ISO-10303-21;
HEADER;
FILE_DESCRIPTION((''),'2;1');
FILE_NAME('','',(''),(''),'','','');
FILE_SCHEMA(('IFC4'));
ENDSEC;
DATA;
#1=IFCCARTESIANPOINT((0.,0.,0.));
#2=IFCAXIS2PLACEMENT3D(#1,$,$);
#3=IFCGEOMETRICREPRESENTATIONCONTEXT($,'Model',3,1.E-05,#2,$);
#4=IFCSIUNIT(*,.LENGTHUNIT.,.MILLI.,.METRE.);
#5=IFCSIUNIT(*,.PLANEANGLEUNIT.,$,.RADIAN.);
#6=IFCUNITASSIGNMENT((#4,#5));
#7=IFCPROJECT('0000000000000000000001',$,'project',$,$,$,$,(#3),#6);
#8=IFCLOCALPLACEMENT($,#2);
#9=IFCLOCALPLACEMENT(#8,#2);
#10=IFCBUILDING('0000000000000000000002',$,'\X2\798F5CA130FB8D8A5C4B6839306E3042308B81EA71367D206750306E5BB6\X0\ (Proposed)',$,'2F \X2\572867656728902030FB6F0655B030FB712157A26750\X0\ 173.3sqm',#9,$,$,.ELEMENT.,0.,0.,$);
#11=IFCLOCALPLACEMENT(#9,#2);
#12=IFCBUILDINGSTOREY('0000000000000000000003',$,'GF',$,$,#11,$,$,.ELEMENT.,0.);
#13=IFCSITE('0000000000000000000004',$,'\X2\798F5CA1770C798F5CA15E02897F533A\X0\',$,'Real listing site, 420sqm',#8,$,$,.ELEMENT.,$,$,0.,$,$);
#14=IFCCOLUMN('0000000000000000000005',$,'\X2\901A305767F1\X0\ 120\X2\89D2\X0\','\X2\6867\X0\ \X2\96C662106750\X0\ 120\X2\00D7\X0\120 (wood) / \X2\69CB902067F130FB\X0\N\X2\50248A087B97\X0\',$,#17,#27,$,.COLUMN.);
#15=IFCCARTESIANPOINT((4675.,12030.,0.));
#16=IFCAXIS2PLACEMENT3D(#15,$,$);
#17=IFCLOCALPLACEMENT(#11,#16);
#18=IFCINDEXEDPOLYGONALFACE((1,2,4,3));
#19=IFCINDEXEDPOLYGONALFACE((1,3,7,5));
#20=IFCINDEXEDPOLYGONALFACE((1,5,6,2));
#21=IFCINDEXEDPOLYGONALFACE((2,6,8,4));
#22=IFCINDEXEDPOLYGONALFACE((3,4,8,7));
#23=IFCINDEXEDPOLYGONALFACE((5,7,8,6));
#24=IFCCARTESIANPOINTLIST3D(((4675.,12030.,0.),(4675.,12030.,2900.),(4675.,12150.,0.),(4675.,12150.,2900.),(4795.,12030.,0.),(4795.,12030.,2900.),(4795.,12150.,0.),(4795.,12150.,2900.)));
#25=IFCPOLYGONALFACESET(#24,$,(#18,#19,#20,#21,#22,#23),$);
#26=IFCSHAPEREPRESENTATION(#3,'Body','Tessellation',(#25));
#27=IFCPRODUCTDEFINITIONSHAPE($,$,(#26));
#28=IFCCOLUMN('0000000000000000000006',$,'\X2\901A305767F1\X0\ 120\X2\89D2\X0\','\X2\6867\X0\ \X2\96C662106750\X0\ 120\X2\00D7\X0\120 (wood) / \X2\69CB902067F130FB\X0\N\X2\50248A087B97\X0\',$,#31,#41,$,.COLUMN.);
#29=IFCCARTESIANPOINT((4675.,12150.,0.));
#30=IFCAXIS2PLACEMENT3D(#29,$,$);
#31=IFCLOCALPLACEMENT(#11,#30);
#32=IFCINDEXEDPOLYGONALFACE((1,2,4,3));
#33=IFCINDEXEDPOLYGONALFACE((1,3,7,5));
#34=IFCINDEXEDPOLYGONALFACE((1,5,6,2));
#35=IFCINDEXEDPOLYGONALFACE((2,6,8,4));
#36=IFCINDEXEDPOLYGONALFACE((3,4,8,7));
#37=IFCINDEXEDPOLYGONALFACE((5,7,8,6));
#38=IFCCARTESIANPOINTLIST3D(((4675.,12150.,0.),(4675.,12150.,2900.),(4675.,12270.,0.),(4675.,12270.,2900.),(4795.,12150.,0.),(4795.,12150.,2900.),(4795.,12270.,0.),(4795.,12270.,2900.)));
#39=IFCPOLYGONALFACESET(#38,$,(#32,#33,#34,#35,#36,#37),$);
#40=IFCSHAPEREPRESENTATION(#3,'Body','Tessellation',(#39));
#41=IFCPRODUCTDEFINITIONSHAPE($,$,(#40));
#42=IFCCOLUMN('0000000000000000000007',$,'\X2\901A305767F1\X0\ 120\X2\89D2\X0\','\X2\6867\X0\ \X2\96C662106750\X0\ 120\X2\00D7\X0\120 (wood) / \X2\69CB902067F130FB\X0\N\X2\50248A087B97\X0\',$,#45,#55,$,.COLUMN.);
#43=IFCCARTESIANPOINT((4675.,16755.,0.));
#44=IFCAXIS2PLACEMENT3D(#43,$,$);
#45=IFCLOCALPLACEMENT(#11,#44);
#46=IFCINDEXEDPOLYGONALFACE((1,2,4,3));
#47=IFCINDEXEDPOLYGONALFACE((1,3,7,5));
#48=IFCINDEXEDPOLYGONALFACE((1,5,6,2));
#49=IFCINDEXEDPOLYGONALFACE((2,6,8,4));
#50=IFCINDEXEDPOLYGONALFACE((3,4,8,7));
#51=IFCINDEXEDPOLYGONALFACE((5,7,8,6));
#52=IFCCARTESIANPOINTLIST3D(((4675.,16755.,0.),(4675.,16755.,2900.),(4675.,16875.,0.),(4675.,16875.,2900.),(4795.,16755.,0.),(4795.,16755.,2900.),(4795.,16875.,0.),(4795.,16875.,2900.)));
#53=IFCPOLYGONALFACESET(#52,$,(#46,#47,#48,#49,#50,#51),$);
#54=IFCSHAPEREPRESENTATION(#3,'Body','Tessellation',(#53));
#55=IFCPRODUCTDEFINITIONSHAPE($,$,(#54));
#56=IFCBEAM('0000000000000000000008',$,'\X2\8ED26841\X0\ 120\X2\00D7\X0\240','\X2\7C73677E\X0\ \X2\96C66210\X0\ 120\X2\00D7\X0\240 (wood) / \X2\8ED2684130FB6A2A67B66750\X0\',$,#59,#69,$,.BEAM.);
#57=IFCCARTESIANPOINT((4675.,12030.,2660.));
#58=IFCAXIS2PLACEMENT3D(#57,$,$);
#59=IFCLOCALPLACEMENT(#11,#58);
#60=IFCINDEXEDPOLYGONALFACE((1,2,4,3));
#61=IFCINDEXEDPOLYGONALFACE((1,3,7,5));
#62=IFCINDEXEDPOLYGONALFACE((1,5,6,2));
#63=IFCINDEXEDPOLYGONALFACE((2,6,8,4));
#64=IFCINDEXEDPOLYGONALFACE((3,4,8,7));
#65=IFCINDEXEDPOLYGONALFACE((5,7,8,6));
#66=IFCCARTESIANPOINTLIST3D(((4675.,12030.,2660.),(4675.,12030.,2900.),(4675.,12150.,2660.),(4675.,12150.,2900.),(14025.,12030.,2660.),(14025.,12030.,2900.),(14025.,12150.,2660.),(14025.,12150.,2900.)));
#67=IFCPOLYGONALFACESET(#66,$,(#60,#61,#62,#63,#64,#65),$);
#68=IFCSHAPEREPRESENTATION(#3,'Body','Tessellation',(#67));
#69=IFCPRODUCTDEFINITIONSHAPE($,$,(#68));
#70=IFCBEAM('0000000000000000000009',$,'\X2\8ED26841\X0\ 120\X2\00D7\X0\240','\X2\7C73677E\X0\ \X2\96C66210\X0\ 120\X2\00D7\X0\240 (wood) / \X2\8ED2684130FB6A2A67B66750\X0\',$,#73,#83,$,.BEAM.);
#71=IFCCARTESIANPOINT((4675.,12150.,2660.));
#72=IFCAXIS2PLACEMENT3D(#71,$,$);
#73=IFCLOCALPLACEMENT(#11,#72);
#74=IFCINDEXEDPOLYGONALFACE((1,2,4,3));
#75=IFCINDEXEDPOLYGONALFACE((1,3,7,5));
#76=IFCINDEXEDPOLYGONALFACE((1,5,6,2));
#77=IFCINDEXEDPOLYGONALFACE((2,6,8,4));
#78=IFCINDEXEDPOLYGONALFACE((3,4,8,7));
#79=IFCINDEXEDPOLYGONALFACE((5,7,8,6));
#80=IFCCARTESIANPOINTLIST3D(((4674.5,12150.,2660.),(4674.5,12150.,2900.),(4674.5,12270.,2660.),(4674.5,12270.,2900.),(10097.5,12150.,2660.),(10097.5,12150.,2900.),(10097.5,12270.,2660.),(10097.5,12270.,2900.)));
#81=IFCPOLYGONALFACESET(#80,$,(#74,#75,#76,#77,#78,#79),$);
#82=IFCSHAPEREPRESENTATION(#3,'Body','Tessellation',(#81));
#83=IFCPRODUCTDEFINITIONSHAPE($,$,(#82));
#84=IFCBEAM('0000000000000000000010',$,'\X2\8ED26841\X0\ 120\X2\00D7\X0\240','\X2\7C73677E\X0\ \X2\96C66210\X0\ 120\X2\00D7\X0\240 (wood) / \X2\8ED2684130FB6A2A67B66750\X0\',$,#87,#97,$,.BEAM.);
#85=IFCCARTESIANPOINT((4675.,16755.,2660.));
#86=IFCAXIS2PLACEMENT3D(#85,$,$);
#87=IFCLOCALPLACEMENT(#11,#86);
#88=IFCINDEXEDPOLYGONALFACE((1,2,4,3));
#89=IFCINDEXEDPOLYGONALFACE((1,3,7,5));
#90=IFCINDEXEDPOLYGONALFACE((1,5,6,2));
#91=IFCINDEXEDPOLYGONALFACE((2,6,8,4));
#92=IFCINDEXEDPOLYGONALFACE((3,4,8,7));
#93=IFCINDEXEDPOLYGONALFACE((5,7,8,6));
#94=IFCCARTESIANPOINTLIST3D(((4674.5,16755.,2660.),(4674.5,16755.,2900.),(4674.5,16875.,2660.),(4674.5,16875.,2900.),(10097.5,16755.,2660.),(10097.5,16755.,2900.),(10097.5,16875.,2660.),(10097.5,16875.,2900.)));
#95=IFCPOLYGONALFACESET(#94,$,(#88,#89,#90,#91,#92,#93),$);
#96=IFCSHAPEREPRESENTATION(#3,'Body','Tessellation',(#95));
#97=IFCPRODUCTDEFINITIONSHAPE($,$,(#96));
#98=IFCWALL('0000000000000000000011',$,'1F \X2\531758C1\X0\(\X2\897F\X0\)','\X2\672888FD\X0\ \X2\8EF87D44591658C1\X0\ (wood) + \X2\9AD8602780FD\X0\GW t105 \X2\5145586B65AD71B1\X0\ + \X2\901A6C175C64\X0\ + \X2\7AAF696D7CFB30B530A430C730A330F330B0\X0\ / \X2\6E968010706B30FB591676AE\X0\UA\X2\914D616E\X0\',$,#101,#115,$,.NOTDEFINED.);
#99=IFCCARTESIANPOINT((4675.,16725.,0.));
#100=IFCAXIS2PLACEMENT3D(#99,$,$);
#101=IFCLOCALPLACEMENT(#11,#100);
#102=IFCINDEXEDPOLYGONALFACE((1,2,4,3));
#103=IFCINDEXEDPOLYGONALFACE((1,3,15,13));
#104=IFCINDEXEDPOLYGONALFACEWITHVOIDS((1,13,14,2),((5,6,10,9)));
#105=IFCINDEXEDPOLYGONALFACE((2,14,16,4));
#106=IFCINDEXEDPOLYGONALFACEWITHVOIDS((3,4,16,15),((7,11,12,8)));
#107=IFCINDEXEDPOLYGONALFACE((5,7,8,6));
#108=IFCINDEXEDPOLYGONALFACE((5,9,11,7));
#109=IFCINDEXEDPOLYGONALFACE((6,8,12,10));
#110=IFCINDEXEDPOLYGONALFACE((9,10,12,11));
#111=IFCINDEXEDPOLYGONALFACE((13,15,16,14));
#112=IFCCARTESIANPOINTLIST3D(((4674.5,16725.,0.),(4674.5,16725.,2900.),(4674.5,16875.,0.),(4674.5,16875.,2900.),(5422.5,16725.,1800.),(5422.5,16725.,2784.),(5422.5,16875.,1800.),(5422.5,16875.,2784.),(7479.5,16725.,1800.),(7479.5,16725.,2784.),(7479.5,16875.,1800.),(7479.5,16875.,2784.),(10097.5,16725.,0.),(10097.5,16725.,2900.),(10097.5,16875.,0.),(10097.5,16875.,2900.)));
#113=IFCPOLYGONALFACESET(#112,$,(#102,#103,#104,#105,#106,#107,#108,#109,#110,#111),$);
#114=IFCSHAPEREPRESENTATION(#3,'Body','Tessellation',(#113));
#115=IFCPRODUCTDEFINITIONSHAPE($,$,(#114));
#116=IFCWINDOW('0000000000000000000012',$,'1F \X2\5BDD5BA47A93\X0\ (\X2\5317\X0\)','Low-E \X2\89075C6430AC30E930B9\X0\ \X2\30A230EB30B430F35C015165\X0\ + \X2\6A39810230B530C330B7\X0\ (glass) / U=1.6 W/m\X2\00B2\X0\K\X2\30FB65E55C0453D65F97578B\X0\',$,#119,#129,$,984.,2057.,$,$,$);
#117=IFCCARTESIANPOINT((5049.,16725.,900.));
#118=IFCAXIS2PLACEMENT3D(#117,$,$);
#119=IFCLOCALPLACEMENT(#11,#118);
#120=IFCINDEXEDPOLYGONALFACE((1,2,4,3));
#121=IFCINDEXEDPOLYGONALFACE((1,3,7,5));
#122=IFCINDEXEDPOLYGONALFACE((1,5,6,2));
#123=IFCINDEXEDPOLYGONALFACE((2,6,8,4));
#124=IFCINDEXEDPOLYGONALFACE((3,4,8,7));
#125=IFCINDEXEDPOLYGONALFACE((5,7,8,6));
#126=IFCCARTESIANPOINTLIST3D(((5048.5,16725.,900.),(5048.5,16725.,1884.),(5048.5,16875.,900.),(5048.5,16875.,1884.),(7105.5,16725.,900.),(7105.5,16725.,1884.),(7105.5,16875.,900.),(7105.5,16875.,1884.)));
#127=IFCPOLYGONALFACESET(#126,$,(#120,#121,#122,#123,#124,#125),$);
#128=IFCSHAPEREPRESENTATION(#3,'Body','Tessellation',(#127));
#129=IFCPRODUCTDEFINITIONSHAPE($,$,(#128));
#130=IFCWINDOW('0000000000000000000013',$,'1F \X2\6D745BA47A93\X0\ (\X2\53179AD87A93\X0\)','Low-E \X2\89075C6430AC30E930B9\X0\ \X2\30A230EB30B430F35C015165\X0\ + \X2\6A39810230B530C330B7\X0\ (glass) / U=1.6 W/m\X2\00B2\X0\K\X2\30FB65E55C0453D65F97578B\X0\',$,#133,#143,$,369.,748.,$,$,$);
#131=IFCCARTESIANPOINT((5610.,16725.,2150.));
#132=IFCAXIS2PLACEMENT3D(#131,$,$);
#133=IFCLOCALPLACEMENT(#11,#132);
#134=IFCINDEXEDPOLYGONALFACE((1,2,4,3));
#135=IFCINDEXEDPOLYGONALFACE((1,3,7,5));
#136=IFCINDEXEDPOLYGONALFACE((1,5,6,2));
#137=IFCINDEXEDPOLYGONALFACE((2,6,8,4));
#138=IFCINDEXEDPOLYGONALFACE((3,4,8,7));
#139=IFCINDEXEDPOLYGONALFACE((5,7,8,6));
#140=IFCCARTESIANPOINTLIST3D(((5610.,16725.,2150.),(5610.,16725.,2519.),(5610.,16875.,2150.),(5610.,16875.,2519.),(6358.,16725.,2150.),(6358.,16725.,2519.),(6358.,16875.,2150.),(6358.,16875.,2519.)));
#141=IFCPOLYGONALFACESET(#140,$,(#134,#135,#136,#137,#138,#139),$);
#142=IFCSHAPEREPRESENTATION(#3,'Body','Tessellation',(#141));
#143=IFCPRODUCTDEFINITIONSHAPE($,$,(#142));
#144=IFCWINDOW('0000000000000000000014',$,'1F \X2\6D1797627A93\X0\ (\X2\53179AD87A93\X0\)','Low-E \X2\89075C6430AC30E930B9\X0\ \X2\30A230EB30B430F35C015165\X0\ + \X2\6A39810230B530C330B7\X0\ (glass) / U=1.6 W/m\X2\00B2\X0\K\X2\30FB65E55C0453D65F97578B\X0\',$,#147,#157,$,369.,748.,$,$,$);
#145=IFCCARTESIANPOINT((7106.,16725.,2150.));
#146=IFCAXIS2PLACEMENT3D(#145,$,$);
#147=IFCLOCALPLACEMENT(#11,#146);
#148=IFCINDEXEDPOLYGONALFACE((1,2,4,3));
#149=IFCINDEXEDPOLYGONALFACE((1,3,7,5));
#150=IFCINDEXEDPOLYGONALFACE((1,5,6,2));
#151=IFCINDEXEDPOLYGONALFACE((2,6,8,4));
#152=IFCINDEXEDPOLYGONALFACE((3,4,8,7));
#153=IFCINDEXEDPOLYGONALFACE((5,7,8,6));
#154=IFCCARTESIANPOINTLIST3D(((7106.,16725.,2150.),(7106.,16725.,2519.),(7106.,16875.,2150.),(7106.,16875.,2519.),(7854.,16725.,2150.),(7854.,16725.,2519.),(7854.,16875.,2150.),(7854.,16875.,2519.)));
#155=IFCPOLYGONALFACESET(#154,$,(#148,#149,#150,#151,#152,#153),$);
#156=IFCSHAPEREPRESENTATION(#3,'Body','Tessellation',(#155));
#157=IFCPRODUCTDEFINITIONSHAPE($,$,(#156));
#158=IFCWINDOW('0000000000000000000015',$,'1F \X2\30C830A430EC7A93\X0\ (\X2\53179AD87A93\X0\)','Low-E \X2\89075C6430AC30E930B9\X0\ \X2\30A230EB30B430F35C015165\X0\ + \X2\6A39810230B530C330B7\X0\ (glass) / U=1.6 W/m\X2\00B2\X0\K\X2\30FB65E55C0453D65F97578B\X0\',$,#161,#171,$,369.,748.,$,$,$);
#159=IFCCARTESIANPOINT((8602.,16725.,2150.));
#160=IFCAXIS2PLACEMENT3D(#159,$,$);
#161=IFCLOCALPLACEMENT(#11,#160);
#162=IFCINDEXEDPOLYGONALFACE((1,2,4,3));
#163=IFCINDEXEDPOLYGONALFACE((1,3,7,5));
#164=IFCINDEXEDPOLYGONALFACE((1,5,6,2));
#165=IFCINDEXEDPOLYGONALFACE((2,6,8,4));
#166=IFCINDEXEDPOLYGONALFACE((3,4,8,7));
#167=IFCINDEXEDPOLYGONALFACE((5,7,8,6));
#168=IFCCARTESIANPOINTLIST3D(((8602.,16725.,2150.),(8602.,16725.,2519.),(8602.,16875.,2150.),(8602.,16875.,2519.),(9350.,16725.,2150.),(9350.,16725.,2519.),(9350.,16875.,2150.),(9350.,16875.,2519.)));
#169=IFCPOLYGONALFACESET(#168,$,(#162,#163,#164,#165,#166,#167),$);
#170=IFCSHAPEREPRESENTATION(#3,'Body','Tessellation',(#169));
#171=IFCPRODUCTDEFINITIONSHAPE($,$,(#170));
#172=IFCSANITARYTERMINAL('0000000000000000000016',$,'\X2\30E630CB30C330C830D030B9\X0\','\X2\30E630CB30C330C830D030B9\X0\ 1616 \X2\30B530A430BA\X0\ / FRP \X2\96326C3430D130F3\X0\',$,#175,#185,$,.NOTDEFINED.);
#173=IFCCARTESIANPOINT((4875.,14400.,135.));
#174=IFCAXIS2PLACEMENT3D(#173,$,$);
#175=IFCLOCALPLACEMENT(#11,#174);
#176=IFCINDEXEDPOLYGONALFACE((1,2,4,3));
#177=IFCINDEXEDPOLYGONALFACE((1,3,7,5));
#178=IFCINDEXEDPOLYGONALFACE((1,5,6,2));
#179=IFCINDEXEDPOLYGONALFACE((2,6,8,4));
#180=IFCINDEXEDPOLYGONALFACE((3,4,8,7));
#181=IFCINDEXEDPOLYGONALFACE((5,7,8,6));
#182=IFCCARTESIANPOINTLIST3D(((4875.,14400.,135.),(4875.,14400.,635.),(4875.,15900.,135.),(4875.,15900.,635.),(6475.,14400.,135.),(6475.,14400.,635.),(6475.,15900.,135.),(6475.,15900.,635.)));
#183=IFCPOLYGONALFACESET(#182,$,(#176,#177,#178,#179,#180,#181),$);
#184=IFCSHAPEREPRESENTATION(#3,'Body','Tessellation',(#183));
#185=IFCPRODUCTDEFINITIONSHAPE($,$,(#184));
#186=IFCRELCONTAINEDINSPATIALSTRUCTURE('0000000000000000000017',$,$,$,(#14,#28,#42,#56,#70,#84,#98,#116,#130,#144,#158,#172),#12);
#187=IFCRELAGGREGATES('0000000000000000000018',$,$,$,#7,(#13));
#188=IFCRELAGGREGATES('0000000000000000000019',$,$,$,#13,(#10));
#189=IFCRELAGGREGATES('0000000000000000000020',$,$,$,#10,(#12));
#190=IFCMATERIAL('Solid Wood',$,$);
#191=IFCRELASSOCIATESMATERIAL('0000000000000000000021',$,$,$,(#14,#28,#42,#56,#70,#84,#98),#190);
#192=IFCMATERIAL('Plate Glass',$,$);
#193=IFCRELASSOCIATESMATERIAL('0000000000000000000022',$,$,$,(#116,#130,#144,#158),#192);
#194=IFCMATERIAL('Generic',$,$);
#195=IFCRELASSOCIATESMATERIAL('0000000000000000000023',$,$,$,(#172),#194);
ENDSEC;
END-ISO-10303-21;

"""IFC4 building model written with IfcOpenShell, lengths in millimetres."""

from ifc_helpers import new_model, si_unit, frame, frame_2d, origin, place, context, project, spatial, rectangle, extrude, material, element, fill, save


model = new_model("IFC4")

# Units and contexts
model_context = context("Model", 3, precision=1e-05, world=origin())
ifc_project = project(units=[si_unit("LENGTHUNIT", "METRE", prefix="MILLI"), si_unit("PLANEANGLEUNIT", "RADIAN")], contexts=[model_context])

# Site, building, storey
site_placement = place(None, origin())
site = spatial("IfcSite", under=ifc_project, at=site_placement, Name="福岡県福岡市西区", ObjectType="Real listing site, 420sqm", CompositionType="ELEMENT", RefElevation=0.0)
building_placement = place(site_placement, origin())
building = spatial("IfcBuilding", under=site, at=building_placement, Name="福岡・越屋根のある自然素材の家 (Proposed)", ObjectType="2F 在来木造・漆喰・無垢材 173.3sqm", CompositionType="ELEMENT", ElevationOfRefHeight=0.0, ElevationOfTerrain=0.0)
storey_placement = place(building_placement, origin())
storey = spatial("IfcBuildingStorey", under=building, at=storey_placement, Name="GF", CompositionType="ELEMENT", Elevation=0.0)

# Columns
ifc_material_1 = material(Name="Solid Wood")
column_1_placement = place(storey_placement, frame((4675.0, 12030.0, 0.0)))
element("IfcColumn", 1, at=column_1_placement, inside=storey, material=ifc_material_1, Name="通し柱 120角", Description="桧 集成材 120×120 (wood) / 構造柱・N値計算", PredefinedType="COLUMN", context=model_context, shape_type="SweptSolid", body=[
    extrude(rectangle(XDim=120.0, YDim=120.0, at=frame_2d((60.0, 60.0))), frame((4675.0, 12030.0, 0.0)), (0.0, 0.0, 1.0), 2900.0),
])
column_2_placement = place(storey_placement, frame((4675.0, 12150.0, 0.0)))
element("IfcColumn", 2, at=column_2_placement, inside=storey, material=ifc_material_1, Name="通し柱 120角", Description="桧 集成材 120×120 (wood) / 構造柱・N値計算", PredefinedType="COLUMN", context=model_context, shape_type="SweptSolid", body=[
    extrude(rectangle(XDim=120.0, YDim=120.0, at=frame_2d((60.0, 60.0))), frame((4675.0, 12150.0, 0.0)), (0.0, 0.0, 1.0), 2900.0),
])
column_3_placement = place(storey_placement, frame((4675.0, 16755.0, 0.0)))
element("IfcColumn", 3, at=column_3_placement, inside=storey, material=ifc_material_1, Name="通し柱 120角", Description="桧 集成材 120×120 (wood) / 構造柱・N値計算", PredefinedType="COLUMN", context=model_context, shape_type="SweptSolid", body=[
    extrude(rectangle(XDim=120.0, YDim=120.0, at=frame_2d((60.0, 60.0))), frame((4675.0, 16755.0, 0.0)), (0.0, 0.0, 1.0), 2900.0),
])

# Beams
beam_1_placement = place(storey_placement, frame((4675.0, 12030.0, 2660.0)))
element("IfcBeam", 4, at=beam_1_placement, inside=storey, material=ifc_material_1, Name="軒桁 120×240", Description="米松 集成 120×240 (wood) / 軒桁・横架材", PredefinedType="BEAM", context=model_context, shape_type="SweptSolid", body=[
    extrude(rectangle(XDim=9350.0, YDim=120.0, at=frame_2d((4675.0, 60.0))), frame((4675.0, 12030.0, 2660.0)), (0.0, 0.0, 1.0), 240.0),
])
beam_2_placement = place(storey_placement, frame((4675.0, 12150.0, 2660.0)))
element("IfcBeam", 5, at=beam_2_placement, inside=storey, material=ifc_material_1, Name="軒桁 120×240", Description="米松 集成 120×240 (wood) / 軒桁・横架材", PredefinedType="BEAM", context=model_context, shape_type="SweptSolid", body=[
    extrude(rectangle(XDim=5423.0, YDim=120.0, at=frame_2d((2711.0, 60.0))), frame((4675.0, 12150.0, 2660.0)), (0.0, 0.0, 1.0), 240.0),
])
beam_3_placement = place(storey_placement, frame((4675.0, 16755.0, 2660.0)))
element("IfcBeam", 6, at=beam_3_placement, inside=storey, material=ifc_material_1, Name="軒桁 120×240", Description="米松 集成 120×240 (wood) / 軒桁・横架材", PredefinedType="BEAM", context=model_context, shape_type="SweptSolid", body=[
    extrude(rectangle(XDim=5423.0, YDim=120.0, at=frame_2d((2711.0, 60.0))), frame((4675.0, 16755.0, 2660.0)), (0.0, 0.0, 1.0), 240.0),
])

# Wall, openings, windows
wall_1_placement = place(storey_placement, frame((4675.0, 16725.0, 0.0)))
wall_1 = element("IfcWall", 7, at=wall_1_placement, inside=storey, material=ifc_material_1, Name="1F 北壁(西)", Description="木製 軸組外壁 (wood) + 高性能GW t105 充填断熱 + 通気層 + 窯業系サイディング / 準耐火・外皮UA配慮", PredefinedType="NOTDEFINED", context=model_context, shape_type="SweptSolid", body=[
    extrude(rectangle(XDim=5423.0, YDim=150.0, at=frame_2d((2711.0, 75.0))), frame((4675.0, 16725.0, 0.0)), (0.0, 0.0, 1.0), 2900.0),
])
opening_1_placement = place(storey_placement, frame((5049.0, 16725.0, 900.0)))
opening_1 = element("IfcOpeningElement", 8, at=opening_1_placement, cuts=wall_1, PredefinedType="NOTDEFINED", context=model_context, shape_type="SweptSolid", body=[
    extrude(rectangle(XDim=2057.0, YDim=150.0, at=frame_2d((1028.0, 75.0))), frame((5049.0, 16725.0, 900.0)), (0.0, 0.0, 1.0), 984.0),
])
opening_2_placement = place(storey_placement, frame((5610.0, 16725.0, 2150.0)))
opening_2 = element("IfcOpeningElement", 9, at=opening_2_placement, cuts=wall_1, PredefinedType="NOTDEFINED", context=model_context, shape_type="SweptSolid", body=[
    extrude(rectangle(XDim=748.0, YDim=150.0, at=frame_2d((374.0, 75.0))), frame((5610.0, 16725.0, 2150.0)), (0.0, 0.0, 1.0), 369.0),
])
opening_3_placement = place(storey_placement, frame((7106.0, 16725.0, 2150.0)))
opening_3 = element("IfcOpeningElement", 10, at=opening_3_placement, cuts=wall_1, PredefinedType="NOTDEFINED", context=model_context, shape_type="SweptSolid", body=[
    extrude(rectangle(XDim=748.0, YDim=150.0, at=frame_2d((374.0, 75.0))), frame((7106.0, 16725.0, 2150.0)), (0.0, 0.0, 1.0), 369.0),
])
opening_4_placement = place(storey_placement, frame((8602.0, 16725.0, 2150.0)))
opening_4 = element("IfcOpeningElement", 11, at=opening_4_placement, cuts=wall_1, PredefinedType="NOTDEFINED", context=model_context, shape_type="SweptSolid", body=[
    extrude(rectangle(XDim=748.0, YDim=150.0, at=frame_2d((374.0, 75.0))), frame((8602.0, 16725.0, 2150.0)), (0.0, 0.0, 1.0), 369.0),
])
ifc_material_2 = material(Name="Plate Glass")
window_1_placement = place(storey_placement, frame((5049.0, 16725.0, 900.0)))
window_1 = element("IfcWindow", 12, at=window_1_placement, inside=storey, material=ifc_material_2, Name="1F 寝室窓 (北)", Description="Low-E 複層ガラス アルゴン封入 + 樹脂サッシ (glass) / U=1.6 W/m²K・日射取得型", OverallHeight=984.0, OverallWidth=2057.0, context=model_context, shape_type="SweptSolid", body=[
    extrude(rectangle(XDim=2057.0, YDim=150.0, at=frame_2d((1028.0, 75.0))), frame((5049.0, 16725.0, 900.0)), (0.0, 0.0, 1.0), 984.0),
])
fill(opening_1, window_1)
window_2_placement = place(storey_placement, frame((5610.0, 16725.0, 2150.0)))
window_2 = element("IfcWindow", 13, at=window_2_placement, inside=storey, material=ifc_material_2, Name="1F 浴室窓 (北高窓)", Description="Low-E 複層ガラス アルゴン封入 + 樹脂サッシ (glass) / U=1.6 W/m²K・日射取得型", OverallHeight=369.0, OverallWidth=748.0, context=model_context, shape_type="SweptSolid", body=[
    extrude(rectangle(XDim=748.0, YDim=150.0, at=frame_2d((374.0, 75.0))), frame((5610.0, 16725.0, 2150.0)), (0.0, 0.0, 1.0), 369.0),
])
fill(opening_2, window_2)
window_3_placement = place(storey_placement, frame((7106.0, 16725.0, 2150.0)))
window_3 = element("IfcWindow", 14, at=window_3_placement, inside=storey, material=ifc_material_2, Name="1F 洗面窓 (北高窓)", Description="Low-E 複層ガラス アルゴン封入 + 樹脂サッシ (glass) / U=1.6 W/m²K・日射取得型", OverallHeight=369.0, OverallWidth=748.0, context=model_context, shape_type="SweptSolid", body=[
    extrude(rectangle(XDim=748.0, YDim=150.0, at=frame_2d((374.0, 75.0))), frame((7106.0, 16725.0, 2150.0)), (0.0, 0.0, 1.0), 369.0),
])
fill(opening_3, window_3)
window_4_placement = place(storey_placement, frame((8602.0, 16725.0, 2150.0)))
window_4 = element("IfcWindow", 15, at=window_4_placement, inside=storey, material=ifc_material_2, Name="1F トイレ窓 (北高窓)", Description="Low-E 複層ガラス アルゴン封入 + 樹脂サッシ (glass) / U=1.6 W/m²K・日射取得型", OverallHeight=369.0, OverallWidth=748.0, context=model_context, shape_type="SweptSolid", body=[
    extrude(rectangle(XDim=748.0, YDim=150.0, at=frame_2d((374.0, 75.0))), frame((8602.0, 16725.0, 2150.0)), (0.0, 0.0, 1.0), 369.0),
])
fill(opening_4, window_4)

# Shared definitions
ifc_material_3 = material(Name="Generic")

# Sanitary terminal
sanitary_terminal_placement = place(storey_placement, frame((4875.0, 14400.0, 135.0)))
element("IfcSanitaryTerminal", 16, at=sanitary_terminal_placement, inside=storey, material=ifc_material_3, Name="ユニットバス", Description="ユニットバス 1616 サイズ / FRP 防水パン", PredefinedType="NOTDEFINED", context=model_context, shape_type="SweptSolid", body=[
    extrude(rectangle(XDim=1600.0, YDim=1500.0, at=frame_2d((800.0, 750.0))), frame((4875.0, 14400.0, 135.0)), (0.0, 0.0, 1.0), 500.0),
])

save(model, "model.ifc")
